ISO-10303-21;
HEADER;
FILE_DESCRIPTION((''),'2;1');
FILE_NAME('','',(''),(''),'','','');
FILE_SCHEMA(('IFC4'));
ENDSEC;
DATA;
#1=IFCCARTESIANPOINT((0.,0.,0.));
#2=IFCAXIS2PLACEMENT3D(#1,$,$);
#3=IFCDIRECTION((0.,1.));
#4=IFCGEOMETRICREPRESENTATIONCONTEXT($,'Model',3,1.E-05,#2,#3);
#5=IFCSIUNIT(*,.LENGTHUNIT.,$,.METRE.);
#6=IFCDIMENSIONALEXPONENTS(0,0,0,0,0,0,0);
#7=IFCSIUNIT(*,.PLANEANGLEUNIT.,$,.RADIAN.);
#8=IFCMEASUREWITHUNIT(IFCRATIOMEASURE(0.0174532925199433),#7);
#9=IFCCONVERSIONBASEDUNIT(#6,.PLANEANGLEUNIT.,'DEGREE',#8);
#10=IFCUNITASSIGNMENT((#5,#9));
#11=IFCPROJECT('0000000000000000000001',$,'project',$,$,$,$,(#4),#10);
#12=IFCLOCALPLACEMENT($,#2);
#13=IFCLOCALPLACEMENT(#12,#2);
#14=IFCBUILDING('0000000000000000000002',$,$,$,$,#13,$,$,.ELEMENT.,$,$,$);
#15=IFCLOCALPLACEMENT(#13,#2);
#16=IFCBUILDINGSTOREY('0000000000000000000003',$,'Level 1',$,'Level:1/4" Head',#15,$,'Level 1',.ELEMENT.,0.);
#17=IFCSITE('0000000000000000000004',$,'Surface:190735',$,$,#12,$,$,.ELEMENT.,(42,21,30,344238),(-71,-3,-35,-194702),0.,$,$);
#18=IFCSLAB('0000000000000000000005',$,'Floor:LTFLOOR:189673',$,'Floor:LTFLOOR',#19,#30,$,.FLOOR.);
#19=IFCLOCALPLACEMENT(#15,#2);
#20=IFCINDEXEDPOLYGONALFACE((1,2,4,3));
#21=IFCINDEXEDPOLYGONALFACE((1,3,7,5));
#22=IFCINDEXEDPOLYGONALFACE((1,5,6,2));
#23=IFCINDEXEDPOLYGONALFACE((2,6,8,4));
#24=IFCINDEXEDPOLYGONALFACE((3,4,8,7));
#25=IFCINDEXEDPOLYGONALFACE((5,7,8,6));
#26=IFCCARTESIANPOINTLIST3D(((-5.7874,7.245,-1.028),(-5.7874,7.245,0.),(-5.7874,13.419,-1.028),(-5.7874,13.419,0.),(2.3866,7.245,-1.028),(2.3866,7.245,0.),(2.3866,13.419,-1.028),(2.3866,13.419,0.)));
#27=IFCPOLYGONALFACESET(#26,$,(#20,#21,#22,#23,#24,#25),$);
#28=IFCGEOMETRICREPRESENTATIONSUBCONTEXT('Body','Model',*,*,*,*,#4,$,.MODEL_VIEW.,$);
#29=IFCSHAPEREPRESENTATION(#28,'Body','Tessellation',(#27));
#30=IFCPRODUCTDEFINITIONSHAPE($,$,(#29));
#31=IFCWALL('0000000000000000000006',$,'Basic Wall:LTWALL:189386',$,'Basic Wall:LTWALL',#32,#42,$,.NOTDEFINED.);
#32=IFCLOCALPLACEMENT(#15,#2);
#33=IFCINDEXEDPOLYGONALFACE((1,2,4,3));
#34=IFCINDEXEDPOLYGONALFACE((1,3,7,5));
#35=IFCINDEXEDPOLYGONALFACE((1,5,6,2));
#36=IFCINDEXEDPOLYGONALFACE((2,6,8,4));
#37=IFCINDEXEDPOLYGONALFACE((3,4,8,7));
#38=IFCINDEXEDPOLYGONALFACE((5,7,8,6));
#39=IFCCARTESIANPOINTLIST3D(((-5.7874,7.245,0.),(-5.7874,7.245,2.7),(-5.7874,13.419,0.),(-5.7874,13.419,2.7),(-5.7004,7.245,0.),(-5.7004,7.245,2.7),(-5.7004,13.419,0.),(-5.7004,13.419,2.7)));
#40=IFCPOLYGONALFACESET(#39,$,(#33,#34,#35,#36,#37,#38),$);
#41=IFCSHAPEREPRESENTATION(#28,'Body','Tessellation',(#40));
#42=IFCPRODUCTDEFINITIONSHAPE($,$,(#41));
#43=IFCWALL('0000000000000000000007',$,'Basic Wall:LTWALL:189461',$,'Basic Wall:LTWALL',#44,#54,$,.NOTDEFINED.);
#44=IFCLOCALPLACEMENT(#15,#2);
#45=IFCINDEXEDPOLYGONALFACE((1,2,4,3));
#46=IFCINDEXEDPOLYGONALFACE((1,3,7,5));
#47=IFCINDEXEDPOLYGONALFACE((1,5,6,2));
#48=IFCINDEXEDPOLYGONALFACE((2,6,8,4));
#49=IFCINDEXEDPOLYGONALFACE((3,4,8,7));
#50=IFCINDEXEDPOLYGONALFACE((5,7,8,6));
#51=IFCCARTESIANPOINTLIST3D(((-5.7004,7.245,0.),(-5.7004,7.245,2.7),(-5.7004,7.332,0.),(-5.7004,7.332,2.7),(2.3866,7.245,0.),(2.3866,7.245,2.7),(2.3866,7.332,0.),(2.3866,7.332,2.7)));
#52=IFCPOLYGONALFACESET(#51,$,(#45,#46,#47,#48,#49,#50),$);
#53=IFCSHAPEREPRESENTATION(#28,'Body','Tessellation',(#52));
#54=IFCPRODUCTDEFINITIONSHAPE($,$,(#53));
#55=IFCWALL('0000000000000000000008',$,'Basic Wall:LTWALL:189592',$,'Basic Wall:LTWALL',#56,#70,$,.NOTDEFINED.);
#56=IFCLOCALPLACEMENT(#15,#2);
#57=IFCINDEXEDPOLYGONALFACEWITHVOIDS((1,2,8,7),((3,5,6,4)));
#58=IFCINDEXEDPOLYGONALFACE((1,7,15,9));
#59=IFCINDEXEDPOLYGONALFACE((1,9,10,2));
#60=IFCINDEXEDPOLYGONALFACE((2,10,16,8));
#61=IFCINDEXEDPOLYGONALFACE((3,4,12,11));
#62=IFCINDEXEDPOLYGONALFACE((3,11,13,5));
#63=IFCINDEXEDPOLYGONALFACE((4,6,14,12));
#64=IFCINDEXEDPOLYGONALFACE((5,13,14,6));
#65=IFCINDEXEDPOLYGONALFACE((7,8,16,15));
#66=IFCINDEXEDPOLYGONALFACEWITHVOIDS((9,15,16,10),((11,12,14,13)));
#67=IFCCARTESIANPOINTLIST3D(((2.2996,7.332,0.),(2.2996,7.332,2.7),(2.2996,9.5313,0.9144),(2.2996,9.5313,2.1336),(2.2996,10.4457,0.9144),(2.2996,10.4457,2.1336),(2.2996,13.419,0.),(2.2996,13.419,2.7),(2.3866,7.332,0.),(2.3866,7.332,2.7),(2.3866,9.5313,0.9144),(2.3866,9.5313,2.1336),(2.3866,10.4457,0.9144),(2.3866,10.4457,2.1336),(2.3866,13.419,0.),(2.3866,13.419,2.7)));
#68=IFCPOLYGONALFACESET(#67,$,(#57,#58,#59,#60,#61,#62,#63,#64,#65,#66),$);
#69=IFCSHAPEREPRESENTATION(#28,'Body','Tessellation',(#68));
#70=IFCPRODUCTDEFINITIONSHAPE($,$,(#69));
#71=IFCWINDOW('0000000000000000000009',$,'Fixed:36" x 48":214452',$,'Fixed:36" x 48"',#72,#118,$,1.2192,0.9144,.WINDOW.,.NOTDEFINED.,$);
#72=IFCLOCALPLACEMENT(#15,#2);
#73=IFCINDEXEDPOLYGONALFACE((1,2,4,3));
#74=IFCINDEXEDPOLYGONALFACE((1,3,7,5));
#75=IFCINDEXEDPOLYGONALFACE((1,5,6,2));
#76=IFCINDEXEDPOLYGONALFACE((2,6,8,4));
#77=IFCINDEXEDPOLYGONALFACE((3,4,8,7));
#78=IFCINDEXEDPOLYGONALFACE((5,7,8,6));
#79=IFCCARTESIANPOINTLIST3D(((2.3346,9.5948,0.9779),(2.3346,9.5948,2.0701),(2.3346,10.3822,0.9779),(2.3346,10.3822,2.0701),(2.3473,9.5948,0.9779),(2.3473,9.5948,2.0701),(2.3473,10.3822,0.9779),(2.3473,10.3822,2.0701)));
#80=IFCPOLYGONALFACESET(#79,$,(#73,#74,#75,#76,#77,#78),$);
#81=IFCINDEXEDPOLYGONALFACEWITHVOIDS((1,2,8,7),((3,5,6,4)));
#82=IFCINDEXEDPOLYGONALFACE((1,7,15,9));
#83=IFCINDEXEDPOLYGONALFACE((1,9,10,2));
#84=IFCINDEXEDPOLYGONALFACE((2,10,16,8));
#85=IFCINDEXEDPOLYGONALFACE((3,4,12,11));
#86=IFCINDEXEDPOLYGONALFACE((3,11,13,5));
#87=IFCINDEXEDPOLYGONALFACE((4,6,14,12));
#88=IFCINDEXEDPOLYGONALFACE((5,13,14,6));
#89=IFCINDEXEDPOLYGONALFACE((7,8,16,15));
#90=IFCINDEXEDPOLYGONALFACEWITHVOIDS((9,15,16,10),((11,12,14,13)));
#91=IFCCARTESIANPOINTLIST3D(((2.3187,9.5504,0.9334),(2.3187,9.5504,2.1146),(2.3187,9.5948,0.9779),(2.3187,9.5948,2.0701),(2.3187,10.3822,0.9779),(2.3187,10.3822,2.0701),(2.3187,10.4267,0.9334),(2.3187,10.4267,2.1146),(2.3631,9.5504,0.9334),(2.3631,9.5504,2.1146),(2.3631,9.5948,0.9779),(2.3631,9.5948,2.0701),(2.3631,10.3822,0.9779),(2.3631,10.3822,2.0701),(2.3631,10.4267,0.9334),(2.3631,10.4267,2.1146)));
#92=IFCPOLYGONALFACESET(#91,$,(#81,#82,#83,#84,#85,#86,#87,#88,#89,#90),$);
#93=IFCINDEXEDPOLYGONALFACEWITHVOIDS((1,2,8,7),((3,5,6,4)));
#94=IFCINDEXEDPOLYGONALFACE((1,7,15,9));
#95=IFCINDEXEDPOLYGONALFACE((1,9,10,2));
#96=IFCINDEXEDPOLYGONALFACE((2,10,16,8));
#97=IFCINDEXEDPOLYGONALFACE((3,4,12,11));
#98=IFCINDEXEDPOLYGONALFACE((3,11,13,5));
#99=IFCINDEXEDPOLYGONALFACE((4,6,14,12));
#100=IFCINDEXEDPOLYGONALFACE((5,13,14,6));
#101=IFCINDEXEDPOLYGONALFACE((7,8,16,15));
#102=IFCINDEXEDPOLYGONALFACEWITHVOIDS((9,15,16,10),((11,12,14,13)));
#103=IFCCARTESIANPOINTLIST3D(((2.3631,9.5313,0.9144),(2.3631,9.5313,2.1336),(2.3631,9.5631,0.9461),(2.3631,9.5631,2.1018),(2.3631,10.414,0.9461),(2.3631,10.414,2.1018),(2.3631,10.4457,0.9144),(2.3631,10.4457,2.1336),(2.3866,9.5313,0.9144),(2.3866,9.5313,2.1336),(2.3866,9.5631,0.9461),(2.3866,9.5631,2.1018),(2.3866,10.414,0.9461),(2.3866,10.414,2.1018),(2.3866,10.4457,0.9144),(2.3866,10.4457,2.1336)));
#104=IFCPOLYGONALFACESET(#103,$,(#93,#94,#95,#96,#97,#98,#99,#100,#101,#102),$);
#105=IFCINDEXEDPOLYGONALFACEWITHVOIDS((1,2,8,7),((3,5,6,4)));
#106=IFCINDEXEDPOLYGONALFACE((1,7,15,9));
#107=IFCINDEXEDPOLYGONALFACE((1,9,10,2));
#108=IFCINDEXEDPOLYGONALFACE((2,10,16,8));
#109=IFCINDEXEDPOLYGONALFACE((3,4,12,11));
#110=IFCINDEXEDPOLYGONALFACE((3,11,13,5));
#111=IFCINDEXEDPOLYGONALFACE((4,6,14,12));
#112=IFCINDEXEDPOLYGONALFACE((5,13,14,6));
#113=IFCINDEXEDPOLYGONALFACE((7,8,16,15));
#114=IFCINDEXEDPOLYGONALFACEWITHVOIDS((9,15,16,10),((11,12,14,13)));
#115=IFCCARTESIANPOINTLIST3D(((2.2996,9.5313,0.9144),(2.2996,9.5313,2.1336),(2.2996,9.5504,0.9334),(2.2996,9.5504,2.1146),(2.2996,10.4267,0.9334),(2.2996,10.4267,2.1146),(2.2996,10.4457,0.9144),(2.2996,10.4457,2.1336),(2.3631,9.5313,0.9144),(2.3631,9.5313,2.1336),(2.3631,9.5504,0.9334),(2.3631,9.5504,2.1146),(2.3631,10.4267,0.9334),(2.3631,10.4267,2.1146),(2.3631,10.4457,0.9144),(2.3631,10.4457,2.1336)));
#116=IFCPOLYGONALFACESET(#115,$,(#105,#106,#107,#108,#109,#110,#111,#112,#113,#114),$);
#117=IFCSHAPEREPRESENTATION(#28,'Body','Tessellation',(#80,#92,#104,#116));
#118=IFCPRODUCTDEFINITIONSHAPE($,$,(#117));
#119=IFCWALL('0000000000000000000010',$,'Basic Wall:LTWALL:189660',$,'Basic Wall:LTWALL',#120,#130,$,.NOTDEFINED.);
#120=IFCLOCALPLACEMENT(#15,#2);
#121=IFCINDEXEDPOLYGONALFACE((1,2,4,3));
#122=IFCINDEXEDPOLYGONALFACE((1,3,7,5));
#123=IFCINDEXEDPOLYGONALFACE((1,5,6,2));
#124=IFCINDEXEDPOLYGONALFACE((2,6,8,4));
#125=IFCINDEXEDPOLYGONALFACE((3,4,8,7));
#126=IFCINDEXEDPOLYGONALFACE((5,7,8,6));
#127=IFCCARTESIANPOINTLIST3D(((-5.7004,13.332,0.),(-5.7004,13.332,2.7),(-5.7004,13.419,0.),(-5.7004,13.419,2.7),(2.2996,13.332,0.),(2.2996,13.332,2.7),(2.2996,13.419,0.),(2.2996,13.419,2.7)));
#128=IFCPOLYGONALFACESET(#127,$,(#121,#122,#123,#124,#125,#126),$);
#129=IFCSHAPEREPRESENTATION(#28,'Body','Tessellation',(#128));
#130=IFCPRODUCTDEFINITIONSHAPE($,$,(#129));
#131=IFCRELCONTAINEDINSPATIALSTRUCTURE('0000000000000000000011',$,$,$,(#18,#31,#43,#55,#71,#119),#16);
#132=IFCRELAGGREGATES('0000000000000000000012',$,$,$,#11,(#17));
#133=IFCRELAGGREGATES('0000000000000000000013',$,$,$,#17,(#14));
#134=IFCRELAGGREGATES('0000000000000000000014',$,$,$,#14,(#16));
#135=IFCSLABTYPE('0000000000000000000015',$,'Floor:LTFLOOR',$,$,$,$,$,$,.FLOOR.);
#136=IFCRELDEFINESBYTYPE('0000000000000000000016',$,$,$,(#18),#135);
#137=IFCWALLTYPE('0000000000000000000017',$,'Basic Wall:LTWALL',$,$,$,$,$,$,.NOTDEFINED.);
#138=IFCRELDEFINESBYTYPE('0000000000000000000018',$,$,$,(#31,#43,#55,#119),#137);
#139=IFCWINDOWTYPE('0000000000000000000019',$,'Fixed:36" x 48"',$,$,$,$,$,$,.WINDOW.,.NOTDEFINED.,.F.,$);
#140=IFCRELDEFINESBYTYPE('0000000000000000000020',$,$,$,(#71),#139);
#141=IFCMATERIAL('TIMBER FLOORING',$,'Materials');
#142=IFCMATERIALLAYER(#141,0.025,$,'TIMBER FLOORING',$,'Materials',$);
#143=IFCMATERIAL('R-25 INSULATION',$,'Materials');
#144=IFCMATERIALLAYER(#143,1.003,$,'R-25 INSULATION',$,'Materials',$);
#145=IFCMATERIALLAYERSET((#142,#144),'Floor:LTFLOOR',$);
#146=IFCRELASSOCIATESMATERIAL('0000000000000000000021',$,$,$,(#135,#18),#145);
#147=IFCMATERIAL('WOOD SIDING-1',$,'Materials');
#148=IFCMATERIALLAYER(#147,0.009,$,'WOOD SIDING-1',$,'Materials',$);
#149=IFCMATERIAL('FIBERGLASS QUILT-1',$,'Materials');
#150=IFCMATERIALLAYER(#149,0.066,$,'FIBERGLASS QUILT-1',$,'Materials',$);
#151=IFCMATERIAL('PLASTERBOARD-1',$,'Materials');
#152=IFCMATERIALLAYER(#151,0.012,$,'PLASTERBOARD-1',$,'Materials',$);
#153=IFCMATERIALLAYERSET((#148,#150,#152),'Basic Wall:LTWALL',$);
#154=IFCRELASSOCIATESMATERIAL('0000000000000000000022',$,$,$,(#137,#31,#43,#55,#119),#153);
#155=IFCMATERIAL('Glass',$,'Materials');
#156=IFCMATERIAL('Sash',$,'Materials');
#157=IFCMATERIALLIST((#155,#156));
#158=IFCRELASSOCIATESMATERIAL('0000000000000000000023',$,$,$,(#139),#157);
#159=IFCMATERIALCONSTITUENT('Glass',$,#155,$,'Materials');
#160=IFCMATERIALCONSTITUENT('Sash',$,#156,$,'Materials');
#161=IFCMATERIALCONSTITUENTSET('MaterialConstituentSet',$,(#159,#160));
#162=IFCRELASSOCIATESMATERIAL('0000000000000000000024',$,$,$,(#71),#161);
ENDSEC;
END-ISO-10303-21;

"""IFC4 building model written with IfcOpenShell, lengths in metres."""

from ifc_helpers import new_model, entity, si_unit, converted_unit, direction, frame, frame_2d, origin, origin_2d_with_axis, place, context, subcontext, project, spatial, polyline, rectangle, outline, extrude, source, transform, mapped, material, material_list, layer, layer_set, layer_usage, constituent, constituent_set, type_object, type_shapes, element, fill, save


model = new_model("IFC4")

# Units and contexts
model_context = context("Model", 3, precision=1e-05, world=origin(), true_north=direction((0.0, 1.0)))
body_context = subcontext(model_context, "Body", "Model", "MODEL_VIEW")
ifc_project = project(units=[si_unit("LENGTHUNIT", "METRE"), converted_unit("PLANEANGLEUNIT", "DEGREE", entity("IfcRatioMeasure", 0.0174532925199433), si_unit("PLANEANGLEUNIT", "RADIAN"), dimensions=[0, 0, 0, 0, 0, 0, 0])], contexts=[model_context])

# Site, building, storey
site_placement = place(None, origin())
site = spatial("IfcSite", under=ifc_project, at=site_placement, Name="Surface:190735", CompositionType="ELEMENT", RefLatitude=(42, 21, 30, 344238), RefLongitude=(-71, -3, -35, -194702), RefElevation=0.0)
building_placement = place(site_placement, origin())
building = spatial("IfcBuilding", under=site, at=building_placement, CompositionType="ELEMENT")
storey_placement = place(building_placement, origin())
storey = spatial("IfcBuildingStorey", under=building, at=storey_placement, Name="Level 1", ObjectType="Level:1/4\" Head", LongName="Level 1", CompositionType="ELEMENT", Elevation=0.0)

# Slab
ifc_material_1 = material(Name="TIMBER FLOORING", Category="Materials")
ifc_layer_1 = layer(ifc_material_1, 0.025, Name="TIMBER FLOORING", Category="Materials")
ifc_material_2 = material(Name="R-25 INSULATION", Category="Materials")
ifc_layer_2 = layer(ifc_material_2, 1.003, Name="R-25 INSULATION", Category="Materials")
ifc_layer_set_1 = layer_set([ifc_layer_1, ifc_layer_2], Name="Floor:LTFLOOR")
ifc_layer_usage_1 = layer_usage(ifc_layer_set_1, "AXIS3", "POSITIVE", 0.0)
slab_type = type_object("IfcSlabType", Name="Floor:LTFLOOR", PredefinedType="FLOOR", material=ifc_layer_set_1)
slab_placement = place(storey_placement, origin())
element("IfcSlab", 1, at=slab_placement, inside=storey, type_object=slab_type, material=ifc_layer_usage_1, Name="Floor:LTFLOOR:189673", ObjectType="Floor:LTFLOOR", PredefinedType="FLOOR", context=body_context, shape_type="SweptSolid", body=[
    extrude(rectangle(XDim=6.174, YDim=8.174, at=frame_2d((0.0, 0.0), x_axis=(1.0, 0.0))), frame((-1.7004, 10.332, 0.0), z_axis=(0.0, 0.0, -1.0), x_axis=(0.0, 1.0, 0.0)), (0.0, 0.0, 1.0), 1.028),
])

# Walls
ifc_material_3 = material(Name="WOOD SIDING-1", Category="Materials")
ifc_layer_3 = layer(ifc_material_3, 0.009, Name="WOOD SIDING-1", Category="Materials")
ifc_material_4 = material(Name="FIBERGLASS QUILT-1", Category="Materials")
ifc_layer_4 = layer(ifc_material_4, 0.066, Name="FIBERGLASS QUILT-1", Category="Materials")
ifc_material_5 = material(Name="PLASTERBOARD-1", Category="Materials")
ifc_layer_5 = layer(ifc_material_5, 0.012, Name="PLASTERBOARD-1", Category="Materials")
ifc_layer_set_2 = layer_set([ifc_layer_3, ifc_layer_4, ifc_layer_5], Name="Basic Wall:LTWALL")
ifc_layer_usage_2 = layer_usage(ifc_layer_set_2, "AXIS2", "NEGATIVE", 0.0435)
wall_type = type_object("IfcWallType", Name="Basic Wall:LTWALL", PredefinedType="NOTDEFINED", material=ifc_layer_set_2)
wall_1_placement = place(storey_placement, frame((-5.7439, 13.419, 0.0), z_axis=(0.0, 0.0, 1.0), x_axis=(0.0, -1.0, 0.0)))
element("IfcWall", 2, at=wall_1_placement, inside=storey, type_object=wall_type, material=ifc_layer_usage_2, Name="Basic Wall:LTWALL:189386", ObjectType="Basic Wall:LTWALL", PredefinedType="NOTDEFINED", context=body_context, shape_type="SweptSolid", body=[
    extrude(rectangle(XDim=6.174, YDim=0.087, at=frame_2d((3.087, 0.0), x_axis=(-1.0, 0.0))), origin(), (0.0, 0.0, 1.0), 2.7),
])
ifc_layer_usage_3 = layer_usage(ifc_layer_set_2, "AXIS2", "NEGATIVE", 0.0435)
wall_2_placement = place(storey_placement, frame((-5.7004, 7.2885, 0.0)))
element("IfcWall", 3, at=wall_2_placement, inside=storey, type_object=wall_type, material=ifc_layer_usage_3, Name="Basic Wall:LTWALL:189461", ObjectType="Basic Wall:LTWALL", PredefinedType="NOTDEFINED", context=body_context, shape_type="SweptSolid", body=[
    extrude(rectangle(XDim=8.087, YDim=0.087, at=frame_2d((4.0435, 0.0), x_axis=(-1.0, 0.0))), origin(), (0.0, 0.0, 1.0), 2.7),
])

# Wall, opening, window
ifc_layer_usage_4 = layer_usage(ifc_layer_set_2, "AXIS2", "NEGATIVE", 0.0435)
wall_3_placement = place(storey_placement, frame((2.3431, 7.332, 0.0), z_axis=(0.0, 0.0, 1.0), x_axis=(0.0, 1.0, 0.0)))
wall_3 = element("IfcWall", 4, at=wall_3_placement, inside=storey, type_object=wall_type, material=ifc_layer_usage_4, Name="Basic Wall:LTWALL:189592", ObjectType="Basic Wall:LTWALL", PredefinedType="NOTDEFINED", context=body_context, shape_type="SweptSolid", body=[
    extrude(rectangle(XDim=6.087, YDim=0.087, at=frame_2d((3.0435, 0.0), x_axis=(-1.0, 0.0))), origin(), (0.0, 0.0, 1.0), 2.7),
])
opening_placement = place(wall_3_placement, frame((2.1993, -0.0435, 0.9144)))
opening = element("IfcOpeningElement", 5, at=opening_placement, cuts=wall_3, ObjectType="Opening", PredefinedType="OPENING", context=body_context, shape_type="SweptSolid", body=[
    extrude(rectangle(XDim=1.2192, YDim=0.9144, at=frame_2d((0.6096, 0.4572), x_axis=(-1.0, 0.0))), frame((0.0, 0.0, 0.0), z_axis=(0.0, 1.0, 0.0), x_axis=(0.0, 0.0, 1.0)), (0.0, 0.0, 1.0), 0.087),
])
ifc_material_6 = material(Name="Glass", Category="Materials")
ifc_constituent_1 = constituent(ifc_material_6, Name="Glass", Category="Materials")
ifc_material_7 = material(Name="Sash", Category="Materials")
ifc_constituent_2 = constituent(ifc_material_7, Name="Sash", Category="Materials")
ifc_constituent_set = constituent_set(constituents=[ifc_constituent_1, ifc_constituent_2], Name="MaterialConstituentSet")
ifc_material_list = material_list([ifc_material_6, ifc_material_7])
window_type = type_object("IfcWindowType", Name="Fixed:36\" x 48\"", ParameterTakesPrecedence=False, PartitioningType="NOTDEFINED", PredefinedType="WINDOW", material=ifc_material_list)
shared_shape = source(origin(), body_context, "Body", "SweptSolid", [
    extrude(rectangle(XDim=0.0127, YDim=0.7874, at=origin_2d_with_axis()), frame((0.4572, 0.0457, 0.0635), z_axis=(0.0, 0.0, 1.0), x_axis=(0.0, 1.0, 0.0)), (0.0, 0.0, 1.0), 1.0922),
    extrude(outline(polyline([(-0.4381, -0.5906), (0.4381, -0.5906), (0.4381, 0.5906), (-0.4381, 0.5906), (-0.4381, -0.5906)]), holes=[polyline([(-0.3937, -0.5461), (-0.3937, 0.5461), (0.3937, 0.5461), (0.3937, -0.5461), (-0.3937, -0.5461)])]), frame((0.4572, 0.0235, 0.6096), z_axis=(0.0, 1.0, 0.0), x_axis=(1.0, 0.0, 0.0)), (0.0, 0.0, 1.0), 0.0445),
    extrude(outline(polyline([(-0.4572, -0.6096), (0.4572, -0.6096), (0.4572, 0.6096), (-0.4572, 0.6096), (-0.4572, -0.6096)]), holes=[polyline([(-0.4255, -0.5778), (-0.4255, 0.5779), (0.4254, 0.5779), (0.4254, -0.5778), (-0.4255, -0.5778)])]), frame((0.4572, 0.0, 0.6096), z_axis=(0.0, 1.0, 0.0), x_axis=(1.0, 0.0, 0.0)), (0.0, 0.0, 1.0), 0.0235),
    extrude(outline(polyline([(-0.6096, -0.4572), (0.6096, -0.4572), (0.6096, 0.4572), (-0.6096, 0.4572), (-0.6096, -0.4572)]), holes=[polyline([(-0.5905, -0.4381), (-0.5905, 0.4381), (0.5906, 0.4381), (0.5906, -0.4381), (-0.5905, -0.4381)])]), frame((0.4572, 0.0235, 0.6096), z_axis=(0.0, 1.0, 0.0), x_axis=(0.0, 0.0, -1.0)), (0.0, 0.0, 1.0), 0.0635),
])
type_shapes(window_type, [shared_shape])
window_placement = place(opening_placement, origin())
window = element("IfcWindow", 6, at=window_placement, inside=storey, type_object=window_type, material=ifc_constituent_set, Name="Fixed:36\" x 48\":214452", ObjectType="Fixed:36\" x 48\"", OverallHeight=1.2192, OverallWidth=0.9144, PartitioningType="NOTDEFINED", PredefinedType="WINDOW", context=body_context, shape_type="MappedRepresentation", body=[
    mapped(shared_shape, transform((0.0, 0.0, 0.0), scale=1.0)),
])
fill(opening, window)

# Wall
ifc_layer_usage_5 = layer_usage(ifc_layer_set_2, "AXIS2", "NEGATIVE", 0.0435)
wall_4_placement = place(storey_placement, frame((2.2996, 13.3755, 0.0), z_axis=(0.0, 0.0, 1.0), x_axis=(-1.0, 0.0, 0.0)))
element("IfcWall", 7, at=wall_4_placement, inside=storey, type_object=wall_type, material=ifc_layer_usage_5, Name="Basic Wall:LTWALL:189660", ObjectType="Basic Wall:LTWALL", PredefinedType="NOTDEFINED", context=body_context, shape_type="SweptSolid", body=[
    extrude(rectangle(XDim=8.0, YDim=0.087, at=frame_2d((4.0, 0.0), x_axis=(-1.0, 0.0))), origin(), (0.0, 0.0, 1.0), 2.7),
])

save(model, "model.ifc")
